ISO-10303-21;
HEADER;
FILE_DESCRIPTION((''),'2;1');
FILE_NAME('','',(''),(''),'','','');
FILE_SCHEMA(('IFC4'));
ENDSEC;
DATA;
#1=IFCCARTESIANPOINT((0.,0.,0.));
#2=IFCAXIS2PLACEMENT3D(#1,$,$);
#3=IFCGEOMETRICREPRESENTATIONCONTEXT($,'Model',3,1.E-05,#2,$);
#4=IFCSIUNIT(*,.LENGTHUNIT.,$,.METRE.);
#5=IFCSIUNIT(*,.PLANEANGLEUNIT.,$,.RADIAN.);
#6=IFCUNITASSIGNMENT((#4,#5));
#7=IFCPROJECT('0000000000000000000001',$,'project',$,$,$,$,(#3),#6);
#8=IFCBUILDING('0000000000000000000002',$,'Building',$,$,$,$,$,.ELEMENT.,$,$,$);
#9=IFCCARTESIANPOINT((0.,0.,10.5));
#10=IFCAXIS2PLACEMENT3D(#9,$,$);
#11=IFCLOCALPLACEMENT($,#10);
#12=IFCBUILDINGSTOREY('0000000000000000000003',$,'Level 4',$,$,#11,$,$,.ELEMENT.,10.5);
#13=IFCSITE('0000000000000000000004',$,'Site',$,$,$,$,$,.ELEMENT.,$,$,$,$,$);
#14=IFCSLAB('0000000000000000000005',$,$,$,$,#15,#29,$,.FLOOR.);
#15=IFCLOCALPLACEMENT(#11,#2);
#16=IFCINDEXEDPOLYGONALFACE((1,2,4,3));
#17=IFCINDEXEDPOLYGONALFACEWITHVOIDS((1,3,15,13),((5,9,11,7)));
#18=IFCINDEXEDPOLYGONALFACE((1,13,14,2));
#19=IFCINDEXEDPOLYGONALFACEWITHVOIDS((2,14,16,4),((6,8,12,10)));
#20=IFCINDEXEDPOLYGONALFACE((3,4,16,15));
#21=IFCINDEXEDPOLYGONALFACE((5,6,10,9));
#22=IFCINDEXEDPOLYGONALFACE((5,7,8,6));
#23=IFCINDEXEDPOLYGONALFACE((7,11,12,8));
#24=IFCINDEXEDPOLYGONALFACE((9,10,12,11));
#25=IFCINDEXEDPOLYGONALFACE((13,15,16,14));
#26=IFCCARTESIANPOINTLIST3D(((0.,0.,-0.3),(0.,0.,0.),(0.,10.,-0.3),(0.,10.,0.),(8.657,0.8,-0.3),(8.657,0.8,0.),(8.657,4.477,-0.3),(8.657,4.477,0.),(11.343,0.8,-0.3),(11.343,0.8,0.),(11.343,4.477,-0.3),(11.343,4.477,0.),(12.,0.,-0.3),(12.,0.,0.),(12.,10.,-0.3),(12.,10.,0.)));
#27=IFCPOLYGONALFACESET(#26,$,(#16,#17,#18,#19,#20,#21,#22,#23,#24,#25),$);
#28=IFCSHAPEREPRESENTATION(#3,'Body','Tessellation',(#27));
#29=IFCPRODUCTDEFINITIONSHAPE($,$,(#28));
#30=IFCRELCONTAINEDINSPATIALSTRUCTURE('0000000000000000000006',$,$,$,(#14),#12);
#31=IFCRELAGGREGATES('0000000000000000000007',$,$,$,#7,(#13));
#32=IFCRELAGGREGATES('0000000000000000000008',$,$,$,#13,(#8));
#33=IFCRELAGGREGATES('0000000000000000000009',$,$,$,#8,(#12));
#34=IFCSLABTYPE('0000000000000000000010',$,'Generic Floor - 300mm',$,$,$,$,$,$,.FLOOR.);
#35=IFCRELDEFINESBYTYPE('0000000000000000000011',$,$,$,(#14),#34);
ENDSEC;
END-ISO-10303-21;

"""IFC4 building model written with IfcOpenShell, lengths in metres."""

from ifc_helpers import new_model, si_unit, frame, origin, place, context, project, spatial, polyline, outline, extrude, type_object, element, save


model = new_model("IFC4")

# Units and contexts
model_context = context("Model", 3, precision=1e-05, world=origin())
ifc_project = project(units=[si_unit("LENGTHUNIT", "METRE"), si_unit("PLANEANGLEUNIT", "RADIAN")], contexts=[model_context])

# Site, building, storey
site = spatial("IfcSite", under=ifc_project, Name="Site", CompositionType="ELEMENT")
building = spatial("IfcBuilding", under=site, Name="Building", CompositionType="ELEMENT")
storey_placement = place(None, frame((0.0, 0.0, 10.5)))
storey = spatial("IfcBuildingStorey", under=building, at=storey_placement, Name="Level 4", CompositionType="ELEMENT", Elevation=10.5)

# Slab, opening
slab_type = type_object("IfcSlabType", Name="Generic Floor - 300mm", PredefinedType="FLOOR")
slab_placement = place(None, frame((0.0, 0.0, 10.5)))
slab = element("IfcSlab", 1, at=slab_placement, inside=storey, type_object=slab_type, PredefinedType="FLOOR", context=model_context, shape_type="SweptSolid", body=[
    extrude(outline(polyline([(0.0, 0.0), (12.0, 0.0), (12.0, 10.0), (0.0, 10.0), (0.0, 0.0)])), origin(), (0.0, 0.0, -1.0), 0.3),
])
opening_placement = place(None, frame((0.0, 0.0, 10.501)))
element("IfcOpeningElement", 2, at=opening_placement, cuts=slab, PredefinedType="OPENING", context=model_context, shape_type="SweptSolid", body=[
    extrude(outline(polyline([(8.657, 0.8), (11.343, 0.8), (11.343, 4.477), (8.657, 4.477), (8.657, 0.8)])), origin(), (0.0, 0.0, -1.0), 0.302),
])

save(model, "model.ifc")
